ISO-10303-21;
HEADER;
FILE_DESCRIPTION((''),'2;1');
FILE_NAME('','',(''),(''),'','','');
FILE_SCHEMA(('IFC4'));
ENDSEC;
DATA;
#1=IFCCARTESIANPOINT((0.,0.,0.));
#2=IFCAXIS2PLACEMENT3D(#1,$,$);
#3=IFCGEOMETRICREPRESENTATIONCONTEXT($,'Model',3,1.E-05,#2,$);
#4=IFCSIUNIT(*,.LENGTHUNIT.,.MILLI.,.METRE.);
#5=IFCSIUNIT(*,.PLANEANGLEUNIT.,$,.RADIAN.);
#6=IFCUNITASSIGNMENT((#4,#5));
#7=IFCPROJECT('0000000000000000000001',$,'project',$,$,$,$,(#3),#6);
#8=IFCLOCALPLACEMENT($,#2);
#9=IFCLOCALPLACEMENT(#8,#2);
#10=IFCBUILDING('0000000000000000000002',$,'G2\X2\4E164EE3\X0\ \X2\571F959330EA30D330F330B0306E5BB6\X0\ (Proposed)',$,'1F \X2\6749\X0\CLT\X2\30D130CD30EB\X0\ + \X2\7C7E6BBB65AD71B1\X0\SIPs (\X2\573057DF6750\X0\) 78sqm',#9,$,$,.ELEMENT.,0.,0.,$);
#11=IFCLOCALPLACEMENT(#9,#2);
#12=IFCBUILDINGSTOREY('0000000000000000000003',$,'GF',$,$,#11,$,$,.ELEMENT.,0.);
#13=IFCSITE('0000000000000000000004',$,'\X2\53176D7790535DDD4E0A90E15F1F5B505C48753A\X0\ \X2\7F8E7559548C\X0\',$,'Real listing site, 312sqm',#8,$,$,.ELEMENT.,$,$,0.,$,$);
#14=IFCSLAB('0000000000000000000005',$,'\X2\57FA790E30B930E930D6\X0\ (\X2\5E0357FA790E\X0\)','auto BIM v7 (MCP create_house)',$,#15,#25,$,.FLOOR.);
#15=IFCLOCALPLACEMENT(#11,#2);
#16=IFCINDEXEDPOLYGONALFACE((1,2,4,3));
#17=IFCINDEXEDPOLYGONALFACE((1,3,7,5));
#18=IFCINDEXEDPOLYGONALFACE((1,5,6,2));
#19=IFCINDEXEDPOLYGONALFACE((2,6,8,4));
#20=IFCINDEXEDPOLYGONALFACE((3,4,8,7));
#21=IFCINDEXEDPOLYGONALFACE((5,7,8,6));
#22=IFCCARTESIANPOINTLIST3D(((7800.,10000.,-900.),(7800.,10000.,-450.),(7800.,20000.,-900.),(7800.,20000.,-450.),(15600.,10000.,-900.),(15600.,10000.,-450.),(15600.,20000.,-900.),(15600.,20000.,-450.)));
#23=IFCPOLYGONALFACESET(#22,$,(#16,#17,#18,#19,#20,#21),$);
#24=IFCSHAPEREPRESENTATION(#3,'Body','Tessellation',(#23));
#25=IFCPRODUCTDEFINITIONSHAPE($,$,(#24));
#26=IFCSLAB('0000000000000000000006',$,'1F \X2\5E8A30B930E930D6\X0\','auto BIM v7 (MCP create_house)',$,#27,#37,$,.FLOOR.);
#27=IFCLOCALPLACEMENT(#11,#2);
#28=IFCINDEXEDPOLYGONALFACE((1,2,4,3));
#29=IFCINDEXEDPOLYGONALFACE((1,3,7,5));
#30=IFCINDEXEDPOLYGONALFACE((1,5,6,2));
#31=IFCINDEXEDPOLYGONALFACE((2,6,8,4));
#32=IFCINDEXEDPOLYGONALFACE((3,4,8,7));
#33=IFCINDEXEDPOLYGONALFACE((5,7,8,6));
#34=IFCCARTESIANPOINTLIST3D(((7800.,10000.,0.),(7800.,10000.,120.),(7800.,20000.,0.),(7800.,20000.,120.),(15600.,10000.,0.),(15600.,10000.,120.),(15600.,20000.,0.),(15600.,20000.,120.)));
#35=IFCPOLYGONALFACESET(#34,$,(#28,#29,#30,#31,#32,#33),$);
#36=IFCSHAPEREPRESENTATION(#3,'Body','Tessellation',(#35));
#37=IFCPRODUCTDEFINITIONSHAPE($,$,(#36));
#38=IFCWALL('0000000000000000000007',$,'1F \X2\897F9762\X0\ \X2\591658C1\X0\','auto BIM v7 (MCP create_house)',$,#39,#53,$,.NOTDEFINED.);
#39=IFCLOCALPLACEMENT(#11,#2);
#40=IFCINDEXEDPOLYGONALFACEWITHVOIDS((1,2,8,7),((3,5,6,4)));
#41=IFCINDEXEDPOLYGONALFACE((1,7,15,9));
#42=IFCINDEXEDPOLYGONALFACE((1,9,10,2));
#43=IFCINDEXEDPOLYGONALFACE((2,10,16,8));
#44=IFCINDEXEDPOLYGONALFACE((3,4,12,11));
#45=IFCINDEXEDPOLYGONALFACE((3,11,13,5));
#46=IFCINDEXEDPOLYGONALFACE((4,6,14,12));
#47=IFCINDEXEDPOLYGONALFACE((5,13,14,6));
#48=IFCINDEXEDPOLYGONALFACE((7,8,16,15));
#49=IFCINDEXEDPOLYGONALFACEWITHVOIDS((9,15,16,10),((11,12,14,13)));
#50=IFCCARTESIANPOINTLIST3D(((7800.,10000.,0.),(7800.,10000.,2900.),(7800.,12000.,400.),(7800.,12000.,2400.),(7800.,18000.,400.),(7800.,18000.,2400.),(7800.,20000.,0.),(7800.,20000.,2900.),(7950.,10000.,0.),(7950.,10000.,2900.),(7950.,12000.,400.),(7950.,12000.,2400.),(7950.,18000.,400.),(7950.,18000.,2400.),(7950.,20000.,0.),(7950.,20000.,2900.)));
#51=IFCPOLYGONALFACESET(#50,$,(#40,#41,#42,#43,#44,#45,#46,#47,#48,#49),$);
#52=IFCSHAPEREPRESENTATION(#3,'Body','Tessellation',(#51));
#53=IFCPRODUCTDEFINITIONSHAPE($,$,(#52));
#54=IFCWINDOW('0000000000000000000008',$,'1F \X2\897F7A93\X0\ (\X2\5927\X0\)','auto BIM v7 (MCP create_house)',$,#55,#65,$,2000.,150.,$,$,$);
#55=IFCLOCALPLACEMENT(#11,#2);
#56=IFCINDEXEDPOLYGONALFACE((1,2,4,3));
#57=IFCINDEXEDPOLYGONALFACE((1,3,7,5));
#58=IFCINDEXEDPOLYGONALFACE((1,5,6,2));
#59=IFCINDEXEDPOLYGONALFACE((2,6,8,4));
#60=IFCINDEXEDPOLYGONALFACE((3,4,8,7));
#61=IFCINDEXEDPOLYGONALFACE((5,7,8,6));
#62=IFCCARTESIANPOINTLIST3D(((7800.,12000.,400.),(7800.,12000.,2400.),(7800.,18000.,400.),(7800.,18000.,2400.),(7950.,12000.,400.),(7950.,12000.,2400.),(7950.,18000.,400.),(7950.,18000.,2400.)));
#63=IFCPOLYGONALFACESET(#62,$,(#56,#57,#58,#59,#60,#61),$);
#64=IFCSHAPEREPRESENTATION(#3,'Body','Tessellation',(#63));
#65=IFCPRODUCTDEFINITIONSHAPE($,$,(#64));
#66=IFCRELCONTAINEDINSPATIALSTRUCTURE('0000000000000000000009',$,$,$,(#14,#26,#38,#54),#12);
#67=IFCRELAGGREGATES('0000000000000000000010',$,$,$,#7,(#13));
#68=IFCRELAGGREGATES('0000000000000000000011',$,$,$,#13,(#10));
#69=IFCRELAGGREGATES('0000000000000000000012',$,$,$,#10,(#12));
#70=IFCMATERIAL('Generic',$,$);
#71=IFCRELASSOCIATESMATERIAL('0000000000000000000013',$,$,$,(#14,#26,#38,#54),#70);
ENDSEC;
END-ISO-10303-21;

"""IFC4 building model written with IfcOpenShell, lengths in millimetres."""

from ifc_helpers import new_model, si_unit, frame, frame_2d, origin, place, context, project, spatial, rectangle, extrude, material, element, fill, save


model = new_model("IFC4")

# Units and contexts
model_context = context("Model", 3, precision=1e-05, world=origin())
ifc_project = project(units=[si_unit("LENGTHUNIT", "METRE", prefix="MILLI"), si_unit("PLANEANGLEUNIT", "RADIAN")], contexts=[model_context])

# Site, building, storey
site_placement = place(None, origin())
site = spatial("IfcSite", under=ifc_project, at=site_placement, Name="北海道川上郡弟子屈町 美留和", ObjectType="Real listing site, 312sqm", CompositionType="ELEMENT", RefElevation=0.0)
building_placement = place(site_placement, origin())
building = spatial("IfcBuilding", under=site, at=building_placement, Name="G2世代 土間リビングの家 (Proposed)", ObjectType="1F 杉CLTパネル + 籾殻断熱SIPs (地域材) 78sqm", CompositionType="ELEMENT", ElevationOfRefHeight=0.0, ElevationOfTerrain=0.0)
storey_placement = place(building_placement, origin())
storey = spatial("IfcBuildingStorey", under=building, at=storey_placement, Name="GF", CompositionType="ELEMENT", Elevation=0.0)

# Slabs
ifc_material = material(Name="Generic")
slab_1_placement = place(storey_placement, frame((3900.0, 5000.0, -450.0)))
element("IfcSlab", 1, at=slab_1_placement, inside=storey, material=ifc_material, Name="基礎スラブ (布基礎)", Description="auto BIM v7 (MCP create_house)", PredefinedType="FLOOR", context=model_context, shape_type="SweptSolid", body=[
    extrude(rectangle(XDim=7800.0, YDim=10000.0, at=frame_2d((3900.0, 5000.0))), frame((3900.0, 5000.0, -450.0)), (0.0, 0.0, 1.0), 450.0),
])
slab_2_placement = place(storey_placement, frame((3900.0, 5000.0, 0.0)))
element("IfcSlab", 2, at=slab_2_placement, inside=storey, material=ifc_material, Name="1F 床スラブ", Description="auto BIM v7 (MCP create_house)", PredefinedType="FLOOR", context=model_context, shape_type="SweptSolid", body=[
    extrude(rectangle(XDim=7800.0, YDim=10000.0, at=frame_2d((3900.0, 5000.0))), frame((3900.0, 5000.0, 0.0)), (0.0, 0.0, 1.0), 120.0),
])

# Wall, opening, window
wall_1_placement = place(storey_placement, frame((3900.0, 5000.0, 0.0)))
wall_1 = element("IfcWall", 3, at=wall_1_placement, inside=storey, material=ifc_material, Name="1F 西面 外壁", Description="auto BIM v7 (MCP create_house)", PredefinedType="NOTDEFINED", context=model_context, shape_type="SweptSolid", body=[
    extrude(rectangle(XDim=150.0, YDim=10000.0, at=frame_2d((75.0, 5000.0))), frame((3900.0, 5000.0, 0.0)), (0.0, 0.0, 1.0), 2900.0),
])
opening_1_placement = place(storey_placement, frame((3900.0, 6000.0, 200.0)))
opening_1 = element("IfcOpeningElement", 4, at=opening_1_placement, cuts=wall_1, PredefinedType="NOTDEFINED", context=model_context, shape_type="SweptSolid", body=[
    extrude(rectangle(XDim=150.0, YDim=6000.0, at=frame_2d((75.0, 3000.0))), frame((3900.0, 6000.0, 200.0)), (0.0, 0.0, 1.0), 2000.0),
])
window_1_placement = place(storey_placement, frame((3900.0, 6000.0, 200.0)))
window_1 = element("IfcWindow", 5, at=window_1_placement, inside=storey, material=ifc_material, Name="1F 西窓 (大)", Description="auto BIM v7 (MCP create_house)", OverallHeight=2000.0, OverallWidth=150.0, context=model_context, shape_type="SweptSolid", body=[
    extrude(rectangle(XDim=150.0, YDim=6000.0, at=frame_2d((75.0, 3000.0))), frame((3900.0, 6000.0, 200.0)), (0.0, 0.0, 1.0), 2000.0),
])
fill(opening_1, window_1)

save(model, "model.ifc")
